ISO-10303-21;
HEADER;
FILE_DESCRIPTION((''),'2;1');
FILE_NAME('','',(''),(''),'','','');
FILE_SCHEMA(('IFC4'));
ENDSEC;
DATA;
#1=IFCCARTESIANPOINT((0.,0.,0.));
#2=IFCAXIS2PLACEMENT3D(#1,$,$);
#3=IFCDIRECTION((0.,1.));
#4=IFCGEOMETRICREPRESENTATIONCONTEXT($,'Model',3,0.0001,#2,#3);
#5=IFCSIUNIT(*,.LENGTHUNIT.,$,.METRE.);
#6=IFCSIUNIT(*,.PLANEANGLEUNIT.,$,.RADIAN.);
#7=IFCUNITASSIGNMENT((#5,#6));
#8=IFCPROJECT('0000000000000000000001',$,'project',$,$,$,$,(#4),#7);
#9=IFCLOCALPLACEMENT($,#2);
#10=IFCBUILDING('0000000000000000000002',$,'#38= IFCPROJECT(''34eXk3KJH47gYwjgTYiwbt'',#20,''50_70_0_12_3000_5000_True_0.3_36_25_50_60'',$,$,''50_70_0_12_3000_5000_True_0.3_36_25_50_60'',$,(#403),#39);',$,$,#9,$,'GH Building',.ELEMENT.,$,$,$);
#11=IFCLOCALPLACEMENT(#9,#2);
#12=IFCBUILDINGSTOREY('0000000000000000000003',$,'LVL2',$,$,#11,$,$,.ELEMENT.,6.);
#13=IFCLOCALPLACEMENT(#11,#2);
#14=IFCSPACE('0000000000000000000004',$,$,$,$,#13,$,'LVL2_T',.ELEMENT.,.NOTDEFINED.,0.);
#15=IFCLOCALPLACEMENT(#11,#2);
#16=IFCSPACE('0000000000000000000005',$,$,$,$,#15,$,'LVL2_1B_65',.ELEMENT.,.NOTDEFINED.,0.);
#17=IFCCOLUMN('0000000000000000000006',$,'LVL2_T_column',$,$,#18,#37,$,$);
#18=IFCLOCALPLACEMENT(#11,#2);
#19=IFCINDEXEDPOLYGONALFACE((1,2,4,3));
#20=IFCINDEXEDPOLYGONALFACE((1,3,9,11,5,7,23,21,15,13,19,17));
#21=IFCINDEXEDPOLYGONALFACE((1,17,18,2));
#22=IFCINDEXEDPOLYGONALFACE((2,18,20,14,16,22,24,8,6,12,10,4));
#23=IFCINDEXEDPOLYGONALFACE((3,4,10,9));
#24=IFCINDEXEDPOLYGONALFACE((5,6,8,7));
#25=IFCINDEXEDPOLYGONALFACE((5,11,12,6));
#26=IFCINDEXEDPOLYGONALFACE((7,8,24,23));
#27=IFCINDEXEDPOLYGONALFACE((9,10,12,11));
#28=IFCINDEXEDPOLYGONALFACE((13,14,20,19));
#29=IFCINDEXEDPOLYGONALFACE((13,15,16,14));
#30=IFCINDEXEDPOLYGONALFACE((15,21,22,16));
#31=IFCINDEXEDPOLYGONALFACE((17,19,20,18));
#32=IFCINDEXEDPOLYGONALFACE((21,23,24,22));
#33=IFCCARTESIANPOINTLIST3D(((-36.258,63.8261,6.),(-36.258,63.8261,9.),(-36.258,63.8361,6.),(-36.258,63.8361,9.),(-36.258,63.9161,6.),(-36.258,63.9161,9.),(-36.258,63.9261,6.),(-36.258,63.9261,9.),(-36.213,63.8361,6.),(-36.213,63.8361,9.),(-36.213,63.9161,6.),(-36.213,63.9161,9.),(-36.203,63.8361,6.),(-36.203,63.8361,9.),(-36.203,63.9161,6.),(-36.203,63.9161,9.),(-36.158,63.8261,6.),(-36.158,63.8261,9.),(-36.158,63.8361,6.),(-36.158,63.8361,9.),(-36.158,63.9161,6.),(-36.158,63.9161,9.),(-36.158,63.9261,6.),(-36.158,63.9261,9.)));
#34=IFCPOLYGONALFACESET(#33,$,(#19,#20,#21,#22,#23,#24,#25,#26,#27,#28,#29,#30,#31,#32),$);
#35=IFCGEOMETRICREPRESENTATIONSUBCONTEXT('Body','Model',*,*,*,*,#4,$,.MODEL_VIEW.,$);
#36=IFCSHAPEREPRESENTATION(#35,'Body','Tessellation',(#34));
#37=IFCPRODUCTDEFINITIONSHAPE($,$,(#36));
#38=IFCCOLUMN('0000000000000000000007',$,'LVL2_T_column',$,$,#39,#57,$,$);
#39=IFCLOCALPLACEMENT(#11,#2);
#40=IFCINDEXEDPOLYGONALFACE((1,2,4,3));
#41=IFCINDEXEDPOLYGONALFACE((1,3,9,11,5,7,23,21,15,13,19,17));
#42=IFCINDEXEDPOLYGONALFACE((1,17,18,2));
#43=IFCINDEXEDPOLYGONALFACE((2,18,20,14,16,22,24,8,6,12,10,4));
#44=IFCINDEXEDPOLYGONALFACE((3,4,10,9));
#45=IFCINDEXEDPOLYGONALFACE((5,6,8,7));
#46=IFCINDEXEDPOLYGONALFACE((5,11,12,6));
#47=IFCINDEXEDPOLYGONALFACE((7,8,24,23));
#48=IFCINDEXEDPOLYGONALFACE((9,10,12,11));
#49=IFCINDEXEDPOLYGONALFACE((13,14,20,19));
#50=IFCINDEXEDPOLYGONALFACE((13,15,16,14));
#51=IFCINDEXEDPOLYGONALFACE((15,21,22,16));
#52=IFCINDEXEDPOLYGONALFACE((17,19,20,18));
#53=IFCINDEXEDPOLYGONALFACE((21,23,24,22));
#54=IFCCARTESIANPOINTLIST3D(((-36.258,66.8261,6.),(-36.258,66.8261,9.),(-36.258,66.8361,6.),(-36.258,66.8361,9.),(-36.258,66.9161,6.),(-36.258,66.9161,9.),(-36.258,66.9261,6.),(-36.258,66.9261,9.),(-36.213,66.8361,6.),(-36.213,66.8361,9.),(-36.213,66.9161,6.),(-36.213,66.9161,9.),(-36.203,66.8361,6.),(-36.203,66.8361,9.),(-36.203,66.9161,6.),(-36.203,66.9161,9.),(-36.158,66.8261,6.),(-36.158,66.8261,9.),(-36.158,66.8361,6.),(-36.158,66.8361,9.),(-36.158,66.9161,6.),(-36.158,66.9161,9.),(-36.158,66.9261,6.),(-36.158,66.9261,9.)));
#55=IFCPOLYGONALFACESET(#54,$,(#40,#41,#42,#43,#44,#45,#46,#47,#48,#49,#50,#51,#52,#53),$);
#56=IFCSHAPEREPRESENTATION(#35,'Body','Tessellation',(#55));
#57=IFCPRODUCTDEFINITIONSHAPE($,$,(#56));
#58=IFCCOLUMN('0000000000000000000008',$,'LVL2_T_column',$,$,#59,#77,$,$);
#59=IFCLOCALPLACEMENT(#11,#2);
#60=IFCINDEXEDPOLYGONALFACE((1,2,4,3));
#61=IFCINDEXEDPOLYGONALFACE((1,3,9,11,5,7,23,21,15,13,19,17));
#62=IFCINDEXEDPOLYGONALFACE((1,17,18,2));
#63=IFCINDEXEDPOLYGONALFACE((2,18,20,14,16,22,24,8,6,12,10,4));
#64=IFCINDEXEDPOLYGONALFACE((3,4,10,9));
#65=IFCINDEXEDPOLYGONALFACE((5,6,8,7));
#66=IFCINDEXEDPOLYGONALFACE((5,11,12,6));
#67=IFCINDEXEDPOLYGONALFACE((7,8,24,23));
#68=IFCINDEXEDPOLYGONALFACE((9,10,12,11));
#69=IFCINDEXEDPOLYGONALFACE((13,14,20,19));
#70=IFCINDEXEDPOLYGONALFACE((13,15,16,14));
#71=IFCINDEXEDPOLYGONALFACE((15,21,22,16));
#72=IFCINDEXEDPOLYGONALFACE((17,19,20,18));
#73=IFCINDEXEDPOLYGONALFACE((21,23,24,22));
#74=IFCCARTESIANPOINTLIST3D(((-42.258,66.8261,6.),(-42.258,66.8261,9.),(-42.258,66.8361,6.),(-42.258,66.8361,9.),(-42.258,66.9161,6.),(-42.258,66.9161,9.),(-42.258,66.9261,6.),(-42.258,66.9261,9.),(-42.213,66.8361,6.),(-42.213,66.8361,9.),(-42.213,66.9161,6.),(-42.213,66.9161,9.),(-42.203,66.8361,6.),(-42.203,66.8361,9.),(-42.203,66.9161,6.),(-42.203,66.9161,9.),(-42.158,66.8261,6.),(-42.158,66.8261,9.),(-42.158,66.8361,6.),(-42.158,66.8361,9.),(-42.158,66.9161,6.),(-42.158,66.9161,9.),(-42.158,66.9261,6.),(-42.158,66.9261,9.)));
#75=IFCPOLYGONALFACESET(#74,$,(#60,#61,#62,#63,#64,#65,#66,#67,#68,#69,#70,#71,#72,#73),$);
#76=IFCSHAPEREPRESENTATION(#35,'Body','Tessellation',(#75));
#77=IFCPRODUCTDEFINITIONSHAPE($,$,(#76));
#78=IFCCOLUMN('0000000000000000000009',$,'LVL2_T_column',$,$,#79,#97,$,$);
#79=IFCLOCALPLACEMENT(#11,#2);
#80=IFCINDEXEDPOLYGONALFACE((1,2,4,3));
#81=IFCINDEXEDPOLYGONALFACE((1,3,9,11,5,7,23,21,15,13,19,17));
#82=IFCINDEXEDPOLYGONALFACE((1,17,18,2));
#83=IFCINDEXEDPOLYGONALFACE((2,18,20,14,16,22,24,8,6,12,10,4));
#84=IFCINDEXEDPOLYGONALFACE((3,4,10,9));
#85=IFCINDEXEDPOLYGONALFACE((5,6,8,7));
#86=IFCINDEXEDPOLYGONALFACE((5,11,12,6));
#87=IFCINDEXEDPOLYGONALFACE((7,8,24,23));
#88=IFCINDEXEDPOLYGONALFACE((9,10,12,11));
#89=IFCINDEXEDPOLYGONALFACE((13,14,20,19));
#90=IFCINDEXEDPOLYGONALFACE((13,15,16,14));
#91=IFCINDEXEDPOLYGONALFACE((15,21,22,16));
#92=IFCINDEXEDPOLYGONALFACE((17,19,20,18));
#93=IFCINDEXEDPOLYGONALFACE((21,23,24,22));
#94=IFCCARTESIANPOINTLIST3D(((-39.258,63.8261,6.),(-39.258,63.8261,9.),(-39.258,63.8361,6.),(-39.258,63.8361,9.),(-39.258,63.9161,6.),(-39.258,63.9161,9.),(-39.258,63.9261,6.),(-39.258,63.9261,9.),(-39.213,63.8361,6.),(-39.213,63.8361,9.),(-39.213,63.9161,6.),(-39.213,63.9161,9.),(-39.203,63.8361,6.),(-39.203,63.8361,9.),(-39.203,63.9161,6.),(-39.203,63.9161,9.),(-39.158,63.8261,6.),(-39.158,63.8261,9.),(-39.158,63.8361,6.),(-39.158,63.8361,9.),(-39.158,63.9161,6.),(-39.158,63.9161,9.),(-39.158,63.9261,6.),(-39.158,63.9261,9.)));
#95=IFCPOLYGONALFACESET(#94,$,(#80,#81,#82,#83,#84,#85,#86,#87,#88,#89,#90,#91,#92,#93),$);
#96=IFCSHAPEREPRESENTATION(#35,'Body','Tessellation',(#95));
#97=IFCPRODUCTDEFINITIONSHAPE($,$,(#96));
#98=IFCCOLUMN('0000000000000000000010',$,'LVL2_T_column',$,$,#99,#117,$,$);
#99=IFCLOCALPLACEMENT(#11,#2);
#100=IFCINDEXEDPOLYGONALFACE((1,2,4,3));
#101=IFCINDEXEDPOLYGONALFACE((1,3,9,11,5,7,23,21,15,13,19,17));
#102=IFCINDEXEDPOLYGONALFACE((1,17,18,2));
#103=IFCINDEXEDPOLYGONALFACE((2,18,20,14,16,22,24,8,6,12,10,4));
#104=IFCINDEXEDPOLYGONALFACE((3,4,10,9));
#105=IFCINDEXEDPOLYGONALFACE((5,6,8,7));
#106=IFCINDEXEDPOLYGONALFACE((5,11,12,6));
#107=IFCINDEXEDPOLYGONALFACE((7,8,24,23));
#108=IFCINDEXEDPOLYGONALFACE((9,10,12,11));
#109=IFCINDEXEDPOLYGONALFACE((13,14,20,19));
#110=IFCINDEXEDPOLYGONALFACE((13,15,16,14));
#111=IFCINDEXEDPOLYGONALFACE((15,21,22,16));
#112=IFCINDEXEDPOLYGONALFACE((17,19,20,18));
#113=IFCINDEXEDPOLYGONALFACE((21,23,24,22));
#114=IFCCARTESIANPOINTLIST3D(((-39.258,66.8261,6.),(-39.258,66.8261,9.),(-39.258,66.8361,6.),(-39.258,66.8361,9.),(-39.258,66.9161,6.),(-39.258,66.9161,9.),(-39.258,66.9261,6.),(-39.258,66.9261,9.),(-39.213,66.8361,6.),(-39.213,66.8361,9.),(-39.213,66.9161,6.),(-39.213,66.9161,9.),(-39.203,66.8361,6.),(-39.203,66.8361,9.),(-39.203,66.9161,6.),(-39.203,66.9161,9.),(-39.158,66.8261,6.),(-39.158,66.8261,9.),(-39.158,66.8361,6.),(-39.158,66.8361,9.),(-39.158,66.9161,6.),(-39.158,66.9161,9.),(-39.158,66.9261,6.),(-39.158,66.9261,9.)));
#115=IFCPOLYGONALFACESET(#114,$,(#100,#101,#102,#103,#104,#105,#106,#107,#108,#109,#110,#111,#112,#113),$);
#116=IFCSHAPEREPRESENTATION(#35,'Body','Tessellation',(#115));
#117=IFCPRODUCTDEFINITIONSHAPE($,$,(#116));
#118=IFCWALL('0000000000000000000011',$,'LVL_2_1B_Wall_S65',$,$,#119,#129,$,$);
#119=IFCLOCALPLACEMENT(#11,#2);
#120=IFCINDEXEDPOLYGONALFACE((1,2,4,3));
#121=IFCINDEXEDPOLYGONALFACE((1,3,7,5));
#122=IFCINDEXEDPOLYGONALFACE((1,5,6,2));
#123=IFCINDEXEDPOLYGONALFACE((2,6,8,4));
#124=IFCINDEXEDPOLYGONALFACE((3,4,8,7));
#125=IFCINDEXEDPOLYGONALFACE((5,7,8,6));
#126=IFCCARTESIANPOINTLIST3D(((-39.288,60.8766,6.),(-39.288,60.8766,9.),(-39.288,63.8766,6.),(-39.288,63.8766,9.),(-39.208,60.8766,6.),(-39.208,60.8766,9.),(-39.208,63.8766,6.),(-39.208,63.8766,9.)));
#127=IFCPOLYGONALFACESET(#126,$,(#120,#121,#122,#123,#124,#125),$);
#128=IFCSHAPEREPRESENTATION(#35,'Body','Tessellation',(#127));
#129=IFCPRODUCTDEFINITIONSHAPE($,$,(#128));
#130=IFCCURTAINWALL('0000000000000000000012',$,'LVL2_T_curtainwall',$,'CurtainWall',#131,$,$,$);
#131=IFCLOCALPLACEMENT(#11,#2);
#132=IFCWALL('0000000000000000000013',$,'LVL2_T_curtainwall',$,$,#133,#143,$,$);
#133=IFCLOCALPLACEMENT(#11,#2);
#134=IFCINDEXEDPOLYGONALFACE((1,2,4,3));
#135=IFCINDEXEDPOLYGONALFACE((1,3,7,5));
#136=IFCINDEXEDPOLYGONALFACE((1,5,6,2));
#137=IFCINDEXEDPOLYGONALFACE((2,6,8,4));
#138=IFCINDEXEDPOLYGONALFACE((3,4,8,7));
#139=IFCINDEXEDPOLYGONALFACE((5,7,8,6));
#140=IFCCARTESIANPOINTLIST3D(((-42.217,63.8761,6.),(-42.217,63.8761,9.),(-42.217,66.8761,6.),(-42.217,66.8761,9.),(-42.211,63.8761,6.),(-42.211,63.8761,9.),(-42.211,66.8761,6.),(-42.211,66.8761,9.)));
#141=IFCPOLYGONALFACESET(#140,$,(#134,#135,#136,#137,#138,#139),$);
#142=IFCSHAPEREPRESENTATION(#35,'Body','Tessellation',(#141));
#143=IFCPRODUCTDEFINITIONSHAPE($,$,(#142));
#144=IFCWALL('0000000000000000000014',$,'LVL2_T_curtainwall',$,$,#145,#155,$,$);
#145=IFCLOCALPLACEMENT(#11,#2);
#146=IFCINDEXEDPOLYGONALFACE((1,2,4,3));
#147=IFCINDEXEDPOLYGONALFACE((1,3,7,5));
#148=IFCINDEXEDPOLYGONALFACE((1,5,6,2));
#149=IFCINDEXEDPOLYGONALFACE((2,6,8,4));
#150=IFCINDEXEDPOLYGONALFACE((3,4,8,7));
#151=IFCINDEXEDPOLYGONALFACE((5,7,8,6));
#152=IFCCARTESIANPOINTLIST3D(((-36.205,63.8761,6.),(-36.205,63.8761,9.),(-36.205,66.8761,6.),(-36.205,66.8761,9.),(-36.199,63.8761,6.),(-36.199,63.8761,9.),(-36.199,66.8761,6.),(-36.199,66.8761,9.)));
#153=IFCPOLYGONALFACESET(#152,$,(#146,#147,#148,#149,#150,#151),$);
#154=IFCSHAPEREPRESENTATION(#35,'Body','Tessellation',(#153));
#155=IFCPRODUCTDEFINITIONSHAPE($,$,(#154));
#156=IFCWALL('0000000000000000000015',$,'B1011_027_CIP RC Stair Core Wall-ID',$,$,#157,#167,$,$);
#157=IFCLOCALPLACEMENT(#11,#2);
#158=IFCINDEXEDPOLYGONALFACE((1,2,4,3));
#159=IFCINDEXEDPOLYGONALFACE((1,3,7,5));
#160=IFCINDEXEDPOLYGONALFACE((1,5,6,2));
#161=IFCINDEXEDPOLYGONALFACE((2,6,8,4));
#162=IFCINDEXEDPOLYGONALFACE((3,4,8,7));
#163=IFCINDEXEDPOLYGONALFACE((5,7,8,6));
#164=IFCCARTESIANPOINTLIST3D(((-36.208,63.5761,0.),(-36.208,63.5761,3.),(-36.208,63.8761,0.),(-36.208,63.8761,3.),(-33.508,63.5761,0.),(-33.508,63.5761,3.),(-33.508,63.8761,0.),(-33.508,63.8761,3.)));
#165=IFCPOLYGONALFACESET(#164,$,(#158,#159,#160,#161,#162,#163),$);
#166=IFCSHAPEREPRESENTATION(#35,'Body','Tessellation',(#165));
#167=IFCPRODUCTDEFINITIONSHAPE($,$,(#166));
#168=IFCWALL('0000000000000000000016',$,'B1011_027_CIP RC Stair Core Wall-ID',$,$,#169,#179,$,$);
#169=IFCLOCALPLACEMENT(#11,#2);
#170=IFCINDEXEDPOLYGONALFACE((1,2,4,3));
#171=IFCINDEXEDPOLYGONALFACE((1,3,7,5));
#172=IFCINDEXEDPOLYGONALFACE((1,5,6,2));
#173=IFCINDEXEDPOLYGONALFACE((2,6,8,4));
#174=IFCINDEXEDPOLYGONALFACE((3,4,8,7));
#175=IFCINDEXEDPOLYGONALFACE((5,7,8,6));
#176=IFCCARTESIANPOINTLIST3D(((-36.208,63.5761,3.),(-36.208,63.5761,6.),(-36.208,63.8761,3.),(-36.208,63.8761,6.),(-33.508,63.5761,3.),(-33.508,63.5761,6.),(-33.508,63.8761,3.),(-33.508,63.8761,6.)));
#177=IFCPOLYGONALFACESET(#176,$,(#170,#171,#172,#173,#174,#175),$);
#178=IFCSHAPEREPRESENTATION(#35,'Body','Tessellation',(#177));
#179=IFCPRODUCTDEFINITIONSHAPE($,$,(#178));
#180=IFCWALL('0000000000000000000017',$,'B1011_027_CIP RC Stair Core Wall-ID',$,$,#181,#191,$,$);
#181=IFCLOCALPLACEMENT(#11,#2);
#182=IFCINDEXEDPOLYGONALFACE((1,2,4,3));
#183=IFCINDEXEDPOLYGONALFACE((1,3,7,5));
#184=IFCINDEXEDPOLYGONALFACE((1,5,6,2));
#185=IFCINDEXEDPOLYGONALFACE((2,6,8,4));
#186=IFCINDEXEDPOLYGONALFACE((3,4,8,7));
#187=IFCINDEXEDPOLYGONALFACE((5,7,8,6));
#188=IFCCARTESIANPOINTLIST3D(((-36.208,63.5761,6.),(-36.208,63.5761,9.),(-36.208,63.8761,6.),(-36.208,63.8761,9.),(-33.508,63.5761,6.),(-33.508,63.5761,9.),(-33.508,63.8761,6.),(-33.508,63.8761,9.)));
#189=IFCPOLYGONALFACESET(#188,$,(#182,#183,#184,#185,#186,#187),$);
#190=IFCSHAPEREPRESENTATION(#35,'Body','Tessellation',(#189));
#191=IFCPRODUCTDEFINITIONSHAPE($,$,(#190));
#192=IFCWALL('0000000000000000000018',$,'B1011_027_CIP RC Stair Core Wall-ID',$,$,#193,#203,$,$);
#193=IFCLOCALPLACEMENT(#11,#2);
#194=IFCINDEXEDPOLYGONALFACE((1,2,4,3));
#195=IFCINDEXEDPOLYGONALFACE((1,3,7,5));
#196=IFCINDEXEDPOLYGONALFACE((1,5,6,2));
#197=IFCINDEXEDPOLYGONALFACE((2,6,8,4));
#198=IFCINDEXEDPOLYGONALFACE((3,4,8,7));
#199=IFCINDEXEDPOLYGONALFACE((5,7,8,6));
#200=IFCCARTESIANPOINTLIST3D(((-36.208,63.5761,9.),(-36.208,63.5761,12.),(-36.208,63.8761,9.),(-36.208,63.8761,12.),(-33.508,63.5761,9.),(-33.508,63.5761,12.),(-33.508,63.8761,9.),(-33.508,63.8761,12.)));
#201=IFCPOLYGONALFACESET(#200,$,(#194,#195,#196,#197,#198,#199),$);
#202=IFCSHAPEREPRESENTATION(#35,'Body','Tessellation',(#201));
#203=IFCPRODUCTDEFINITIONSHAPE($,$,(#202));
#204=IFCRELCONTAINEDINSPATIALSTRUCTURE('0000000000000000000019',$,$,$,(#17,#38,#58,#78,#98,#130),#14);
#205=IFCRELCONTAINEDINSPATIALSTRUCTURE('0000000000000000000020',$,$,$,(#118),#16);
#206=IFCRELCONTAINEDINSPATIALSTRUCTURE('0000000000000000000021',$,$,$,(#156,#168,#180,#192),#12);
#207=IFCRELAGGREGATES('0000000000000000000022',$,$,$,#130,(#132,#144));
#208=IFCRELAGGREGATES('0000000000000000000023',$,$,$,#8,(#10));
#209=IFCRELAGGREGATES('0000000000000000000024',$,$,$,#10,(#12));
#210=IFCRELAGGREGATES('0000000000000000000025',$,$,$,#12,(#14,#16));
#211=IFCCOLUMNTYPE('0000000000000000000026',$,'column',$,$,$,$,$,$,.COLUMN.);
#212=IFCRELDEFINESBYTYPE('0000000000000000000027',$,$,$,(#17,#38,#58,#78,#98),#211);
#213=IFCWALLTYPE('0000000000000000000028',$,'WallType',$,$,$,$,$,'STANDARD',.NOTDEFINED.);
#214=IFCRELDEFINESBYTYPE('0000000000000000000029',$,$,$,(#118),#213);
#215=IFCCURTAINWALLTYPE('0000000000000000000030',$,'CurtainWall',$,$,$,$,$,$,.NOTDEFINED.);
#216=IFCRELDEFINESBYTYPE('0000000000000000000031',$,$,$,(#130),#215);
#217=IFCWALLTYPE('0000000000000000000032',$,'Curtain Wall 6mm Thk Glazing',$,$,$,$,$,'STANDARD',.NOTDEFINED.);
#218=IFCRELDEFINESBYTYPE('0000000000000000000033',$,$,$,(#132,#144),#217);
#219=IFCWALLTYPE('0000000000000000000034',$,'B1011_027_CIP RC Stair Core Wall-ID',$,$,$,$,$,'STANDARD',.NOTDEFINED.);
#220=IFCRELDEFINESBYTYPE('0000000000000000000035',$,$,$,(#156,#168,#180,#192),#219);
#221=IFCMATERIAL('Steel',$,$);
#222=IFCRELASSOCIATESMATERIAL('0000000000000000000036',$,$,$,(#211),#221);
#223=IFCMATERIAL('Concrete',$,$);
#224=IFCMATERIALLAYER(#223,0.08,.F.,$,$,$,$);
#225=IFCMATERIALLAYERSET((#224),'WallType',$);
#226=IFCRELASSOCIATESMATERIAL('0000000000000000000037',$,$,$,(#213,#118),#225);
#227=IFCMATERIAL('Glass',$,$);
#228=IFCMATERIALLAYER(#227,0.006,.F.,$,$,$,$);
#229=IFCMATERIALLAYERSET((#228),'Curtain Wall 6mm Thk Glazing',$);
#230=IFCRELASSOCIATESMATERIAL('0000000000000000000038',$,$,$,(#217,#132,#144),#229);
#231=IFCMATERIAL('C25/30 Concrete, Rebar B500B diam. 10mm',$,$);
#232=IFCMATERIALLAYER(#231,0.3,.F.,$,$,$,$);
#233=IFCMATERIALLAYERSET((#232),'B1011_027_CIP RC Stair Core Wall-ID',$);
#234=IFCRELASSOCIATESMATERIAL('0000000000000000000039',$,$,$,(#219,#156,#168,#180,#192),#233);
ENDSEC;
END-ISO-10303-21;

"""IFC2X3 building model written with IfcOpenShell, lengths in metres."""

from ifc_helpers import new_model, si_unit, direction, frame, frame_2d, origin, origin_2d, place, context, subcontext, project, spatial, rectangle, i_section, extrude, material, layer, layer_set, layer_usage, type_object, element, aggregate, save


model = new_model("IFC2X3")

# Units and contexts
model_context = context("Model", 3, precision=0.0001, world=origin(), true_north=direction((0.0, 1.0)))
body_context = subcontext(model_context, "Body", "Model", "MODEL_VIEW")
ifc_project = project(units=[si_unit("LENGTHUNIT", "METRE"), si_unit("PLANEANGLEUNIT", "RADIAN")], contexts=[model_context])

# Building, storey, space
building_placement = place(None, origin())
building = spatial("IfcBuilding", under=ifc_project, at=building_placement, Name="#38= IFCPROJECT('34eXk3KJH47gYwjgTYiwbt',#20,'50_70_0_12_3000_5000_True_0.3_36_25_50_60',$,$,'50_70_0_12_3000_5000_True_0.3_36_25_50_60',$,(#403),#39);", LongName="GH Building", CompositionType="ELEMENT")
storey_placement = place(building_placement, origin())
storey = spatial("IfcBuildingStorey", under=building, at=storey_placement, Name="LVL2", CompositionType="ELEMENT", Elevation=6.0)
space_1_placement = place(storey_placement, origin())
space_1 = spatial("IfcSpace", under=storey, at=space_1_placement, LongName="LVL2_T", CompositionType="ELEMENT", InteriorOrExteriorSpace="NOTDEFINED", ElevationWithFlooring=0.0)

# Columns
ifc_material_1 = material(Name="Steel")
column_type = type_object("IfcColumnType", Name="column", PredefinedType="COLUMN", material=ifc_material_1)
for number, where, name in (
    (1, (-36.208, 63.8761, 6.0), "LVL2_T_column"),
    (2, (-36.208, 66.8761, 6.0), "LVL2_T_column"),
    (3, (-42.208, 66.8761, 6.0), "LVL2_T_column"),
    (4, (-39.208, 63.8761, 6.0), "LVL2_T_column"),
    (5, (-39.208, 66.8761, 6.0), "LVL2_T_column"),
):
    element("IfcColumn", number, at=place(space_1_placement, frame(where)), inside=space_1, type_object=column_type, Name=name, context=body_context, shape_type="SweptSolid", body=[
        extrude(i_section(OverallWidth=0.1, OverallDepth=0.1, WebThickness=0.01, FlangeThickness=0.01, at=origin_2d()), origin(), (0.0, 0.0, 1.0), 3.0),
    ])

# Shared definitions
space_2_placement = place(storey_placement, origin())
space_2 = spatial("IfcSpace", under=storey, at=space_2_placement, LongName="LVL2_1B_65", CompositionType="ELEMENT", InteriorOrExteriorSpace="NOTDEFINED", ElevationWithFlooring=0.0)

# Wall
ifc_material_2 = material(Name="Concrete")
ifc_layer_1 = layer(ifc_material_2, 0.08, ventilated=False)
ifc_layer_set_1 = layer_set([ifc_layer_1], Name="WallType")
ifc_layer_usage_1 = layer_usage(ifc_layer_set_1, "AXIS2", "NEGATIVE", 0.0)
wall_type_1 = type_object("IfcWallType", Name="WallType", ElementType="STANDARD", PredefinedType="NOTDEFINED", material=ifc_layer_set_1)
wall_1_placement = place(space_2_placement, frame((-39.208, 63.8766, 6.0), z_axis=(0.0, 0.0, 1.0), x_axis=(0.0, -1.0, 0.0)))
element("IfcWall", 6, at=wall_1_placement, inside=space_2, type_object=wall_type_1, material=ifc_layer_usage_1, Name="LVL_2_1B_Wall_S65", context=body_context, shape_type="SweptSolid", body=[
    extrude(rectangle(XDim=3.0, YDim=0.08, at=frame_2d((1.5, -0.04))), origin(), (0.0, 0.0, 1.0), 3.0),
])

# Curtain wall, walls
curtain_wall_type = type_object("IfcCurtainWallType", Name="CurtainWall", PredefinedType="NOTDEFINED")
curtain_wall_placement = place(None, origin())
curtain_wall = element("IfcCurtainWall", 7, at=curtain_wall_placement, inside=space_1, type_object=curtain_wall_type, Name="LVL2_T_curtainwall", ObjectType="CurtainWall")
ifc_material_3 = material(Name="Glass")
ifc_layer_2 = layer(ifc_material_3, 0.006, ventilated=False)
ifc_layer_set_2 = layer_set([ifc_layer_2], Name="Curtain Wall 6mm Thk Glazing")
ifc_layer_usage_2 = layer_usage(ifc_layer_set_2, "AXIS2", "NEGATIVE", -0.003)
wall_type_2 = type_object("IfcWallType", Name="Curtain Wall 6mm Thk Glazing", ElementType="STANDARD", PredefinedType="NOTDEFINED", material=ifc_layer_set_2)
wall_2_placement = place(curtain_wall_placement, frame((-42.208, 66.8761, 6.0), z_axis=(0.0, 0.0, 1.0), x_axis=(0.0, -1.0, 0.0)))
wall_2 = element("IfcWall", 8, at=wall_2_placement, type_object=wall_type_2, material=ifc_layer_usage_2, Name="LVL2_T_curtainwall", context=body_context, shape_type="SweptSolid", body=[
    extrude(rectangle(XDim=3.0, YDim=0.006, at=frame_2d((1.5, -0.006))), origin(), (0.0, 0.0, 1.0), 3.0),
])
ifc_layer_usage_3 = layer_usage(ifc_layer_set_2, "AXIS2", "NEGATIVE", -0.003)
wall_3_placement = place(curtain_wall_placement, frame((-36.208, 63.8761, 6.0), z_axis=(0.0, 0.0, 1.0), x_axis=(0.0, 1.0, 0.0)))
wall_3 = element("IfcWall", 9, at=wall_3_placement, type_object=wall_type_2, material=ifc_layer_usage_3, Name="LVL2_T_curtainwall", context=body_context, shape_type="SweptSolid", body=[
    extrude(rectangle(XDim=3.0, YDim=0.006, at=frame_2d((1.5, -0.006))), origin(), (0.0, 0.0, 1.0), 3.0),
])
aggregate(curtain_wall, [wall_2, wall_3])

# Walls
ifc_material_4 = material(Name="C25/30 Concrete, Rebar B500B diam. 10mm")
ifc_layer_3 = layer(ifc_material_4, 0.3, ventilated=False)
ifc_layer_set_3 = layer_set([ifc_layer_3], Name="B1011_027_CIP RC Stair Core Wall-ID")
ifc_layer_usage_4 = layer_usage(ifc_layer_set_3, "AXIS2", "POSITIVE", 0.0)
wall_type_3 = type_object("IfcWallType", Name="B1011_027_CIP RC Stair Core Wall-ID", ElementType="STANDARD", PredefinedType="NOTDEFINED", material=ifc_layer_set_3)
wall_4_placement = place(storey_placement, frame((-33.508, 63.8761, 0.0), z_axis=(0.0, 0.0, 1.0), x_axis=(-1.0, 0.0, 0.0)))
element("IfcWall", 10, at=wall_4_placement, inside=storey, type_object=wall_type_3, material=ifc_layer_usage_4, Name="B1011_027_CIP RC Stair Core Wall-ID", context=body_context, shape_type="SweptSolid", body=[
    extrude(rectangle(XDim=2.7, YDim=0.3, at=frame_2d((1.35, 0.15))), origin(), (0.0, 0.0, 1.0), 3.0),
])
ifc_layer_usage_5 = layer_usage(ifc_layer_set_3, "AXIS2", "POSITIVE", 0.0)
wall_5_placement = place(storey_placement, frame((-33.508, 63.8761, 3.0), z_axis=(0.0, 0.0, 1.0), x_axis=(-1.0, 0.0, 0.0)))
element("IfcWall", 11, at=wall_5_placement, inside=storey, type_object=wall_type_3, material=ifc_layer_usage_5, Name="B1011_027_CIP RC Stair Core Wall-ID", context=body_context, shape_type="SweptSolid", body=[
    extrude(rectangle(XDim=2.7, YDim=0.3, at=frame_2d((1.35, 0.15))), origin(), (0.0, 0.0, 1.0), 3.0),
])
ifc_layer_usage_6 = layer_usage(ifc_layer_set_3, "AXIS2", "POSITIVE", 0.0)
wall_6_placement = place(storey_placement, frame((-33.508, 63.8761, 6.0), z_axis=(0.0, 0.0, 1.0), x_axis=(-1.0, 0.0, 0.0)))
element("IfcWall", 12, at=wall_6_placement, inside=storey, type_object=wall_type_3, material=ifc_layer_usage_6, Name="B1011_027_CIP RC Stair Core Wall-ID", context=body_context, shape_type="SweptSolid", body=[
    extrude(rectangle(XDim=2.7, YDim=0.3, at=frame_2d((1.35, 0.15))), origin(), (0.0, 0.0, 1.0), 3.0),
])
ifc_layer_usage_7 = layer_usage(ifc_layer_set_3, "AXIS2", "POSITIVE", 0.0)
wall_7_placement = place(storey_placement, frame((-33.508, 63.8761, 9.0), z_axis=(0.0, 0.0, 1.0), x_axis=(-1.0, 0.0, 0.0)))
element("IfcWall", 13, at=wall_7_placement, inside=storey, type_object=wall_type_3, material=ifc_layer_usage_7, Name="B1011_027_CIP RC Stair Core Wall-ID", context=body_context, shape_type="SweptSolid", body=[
    extrude(rectangle(XDim=2.7, YDim=0.3, at=frame_2d((1.35, 0.15))), origin(), (0.0, 0.0, 1.0), 3.0),
])

save(model, "model.ifc")
